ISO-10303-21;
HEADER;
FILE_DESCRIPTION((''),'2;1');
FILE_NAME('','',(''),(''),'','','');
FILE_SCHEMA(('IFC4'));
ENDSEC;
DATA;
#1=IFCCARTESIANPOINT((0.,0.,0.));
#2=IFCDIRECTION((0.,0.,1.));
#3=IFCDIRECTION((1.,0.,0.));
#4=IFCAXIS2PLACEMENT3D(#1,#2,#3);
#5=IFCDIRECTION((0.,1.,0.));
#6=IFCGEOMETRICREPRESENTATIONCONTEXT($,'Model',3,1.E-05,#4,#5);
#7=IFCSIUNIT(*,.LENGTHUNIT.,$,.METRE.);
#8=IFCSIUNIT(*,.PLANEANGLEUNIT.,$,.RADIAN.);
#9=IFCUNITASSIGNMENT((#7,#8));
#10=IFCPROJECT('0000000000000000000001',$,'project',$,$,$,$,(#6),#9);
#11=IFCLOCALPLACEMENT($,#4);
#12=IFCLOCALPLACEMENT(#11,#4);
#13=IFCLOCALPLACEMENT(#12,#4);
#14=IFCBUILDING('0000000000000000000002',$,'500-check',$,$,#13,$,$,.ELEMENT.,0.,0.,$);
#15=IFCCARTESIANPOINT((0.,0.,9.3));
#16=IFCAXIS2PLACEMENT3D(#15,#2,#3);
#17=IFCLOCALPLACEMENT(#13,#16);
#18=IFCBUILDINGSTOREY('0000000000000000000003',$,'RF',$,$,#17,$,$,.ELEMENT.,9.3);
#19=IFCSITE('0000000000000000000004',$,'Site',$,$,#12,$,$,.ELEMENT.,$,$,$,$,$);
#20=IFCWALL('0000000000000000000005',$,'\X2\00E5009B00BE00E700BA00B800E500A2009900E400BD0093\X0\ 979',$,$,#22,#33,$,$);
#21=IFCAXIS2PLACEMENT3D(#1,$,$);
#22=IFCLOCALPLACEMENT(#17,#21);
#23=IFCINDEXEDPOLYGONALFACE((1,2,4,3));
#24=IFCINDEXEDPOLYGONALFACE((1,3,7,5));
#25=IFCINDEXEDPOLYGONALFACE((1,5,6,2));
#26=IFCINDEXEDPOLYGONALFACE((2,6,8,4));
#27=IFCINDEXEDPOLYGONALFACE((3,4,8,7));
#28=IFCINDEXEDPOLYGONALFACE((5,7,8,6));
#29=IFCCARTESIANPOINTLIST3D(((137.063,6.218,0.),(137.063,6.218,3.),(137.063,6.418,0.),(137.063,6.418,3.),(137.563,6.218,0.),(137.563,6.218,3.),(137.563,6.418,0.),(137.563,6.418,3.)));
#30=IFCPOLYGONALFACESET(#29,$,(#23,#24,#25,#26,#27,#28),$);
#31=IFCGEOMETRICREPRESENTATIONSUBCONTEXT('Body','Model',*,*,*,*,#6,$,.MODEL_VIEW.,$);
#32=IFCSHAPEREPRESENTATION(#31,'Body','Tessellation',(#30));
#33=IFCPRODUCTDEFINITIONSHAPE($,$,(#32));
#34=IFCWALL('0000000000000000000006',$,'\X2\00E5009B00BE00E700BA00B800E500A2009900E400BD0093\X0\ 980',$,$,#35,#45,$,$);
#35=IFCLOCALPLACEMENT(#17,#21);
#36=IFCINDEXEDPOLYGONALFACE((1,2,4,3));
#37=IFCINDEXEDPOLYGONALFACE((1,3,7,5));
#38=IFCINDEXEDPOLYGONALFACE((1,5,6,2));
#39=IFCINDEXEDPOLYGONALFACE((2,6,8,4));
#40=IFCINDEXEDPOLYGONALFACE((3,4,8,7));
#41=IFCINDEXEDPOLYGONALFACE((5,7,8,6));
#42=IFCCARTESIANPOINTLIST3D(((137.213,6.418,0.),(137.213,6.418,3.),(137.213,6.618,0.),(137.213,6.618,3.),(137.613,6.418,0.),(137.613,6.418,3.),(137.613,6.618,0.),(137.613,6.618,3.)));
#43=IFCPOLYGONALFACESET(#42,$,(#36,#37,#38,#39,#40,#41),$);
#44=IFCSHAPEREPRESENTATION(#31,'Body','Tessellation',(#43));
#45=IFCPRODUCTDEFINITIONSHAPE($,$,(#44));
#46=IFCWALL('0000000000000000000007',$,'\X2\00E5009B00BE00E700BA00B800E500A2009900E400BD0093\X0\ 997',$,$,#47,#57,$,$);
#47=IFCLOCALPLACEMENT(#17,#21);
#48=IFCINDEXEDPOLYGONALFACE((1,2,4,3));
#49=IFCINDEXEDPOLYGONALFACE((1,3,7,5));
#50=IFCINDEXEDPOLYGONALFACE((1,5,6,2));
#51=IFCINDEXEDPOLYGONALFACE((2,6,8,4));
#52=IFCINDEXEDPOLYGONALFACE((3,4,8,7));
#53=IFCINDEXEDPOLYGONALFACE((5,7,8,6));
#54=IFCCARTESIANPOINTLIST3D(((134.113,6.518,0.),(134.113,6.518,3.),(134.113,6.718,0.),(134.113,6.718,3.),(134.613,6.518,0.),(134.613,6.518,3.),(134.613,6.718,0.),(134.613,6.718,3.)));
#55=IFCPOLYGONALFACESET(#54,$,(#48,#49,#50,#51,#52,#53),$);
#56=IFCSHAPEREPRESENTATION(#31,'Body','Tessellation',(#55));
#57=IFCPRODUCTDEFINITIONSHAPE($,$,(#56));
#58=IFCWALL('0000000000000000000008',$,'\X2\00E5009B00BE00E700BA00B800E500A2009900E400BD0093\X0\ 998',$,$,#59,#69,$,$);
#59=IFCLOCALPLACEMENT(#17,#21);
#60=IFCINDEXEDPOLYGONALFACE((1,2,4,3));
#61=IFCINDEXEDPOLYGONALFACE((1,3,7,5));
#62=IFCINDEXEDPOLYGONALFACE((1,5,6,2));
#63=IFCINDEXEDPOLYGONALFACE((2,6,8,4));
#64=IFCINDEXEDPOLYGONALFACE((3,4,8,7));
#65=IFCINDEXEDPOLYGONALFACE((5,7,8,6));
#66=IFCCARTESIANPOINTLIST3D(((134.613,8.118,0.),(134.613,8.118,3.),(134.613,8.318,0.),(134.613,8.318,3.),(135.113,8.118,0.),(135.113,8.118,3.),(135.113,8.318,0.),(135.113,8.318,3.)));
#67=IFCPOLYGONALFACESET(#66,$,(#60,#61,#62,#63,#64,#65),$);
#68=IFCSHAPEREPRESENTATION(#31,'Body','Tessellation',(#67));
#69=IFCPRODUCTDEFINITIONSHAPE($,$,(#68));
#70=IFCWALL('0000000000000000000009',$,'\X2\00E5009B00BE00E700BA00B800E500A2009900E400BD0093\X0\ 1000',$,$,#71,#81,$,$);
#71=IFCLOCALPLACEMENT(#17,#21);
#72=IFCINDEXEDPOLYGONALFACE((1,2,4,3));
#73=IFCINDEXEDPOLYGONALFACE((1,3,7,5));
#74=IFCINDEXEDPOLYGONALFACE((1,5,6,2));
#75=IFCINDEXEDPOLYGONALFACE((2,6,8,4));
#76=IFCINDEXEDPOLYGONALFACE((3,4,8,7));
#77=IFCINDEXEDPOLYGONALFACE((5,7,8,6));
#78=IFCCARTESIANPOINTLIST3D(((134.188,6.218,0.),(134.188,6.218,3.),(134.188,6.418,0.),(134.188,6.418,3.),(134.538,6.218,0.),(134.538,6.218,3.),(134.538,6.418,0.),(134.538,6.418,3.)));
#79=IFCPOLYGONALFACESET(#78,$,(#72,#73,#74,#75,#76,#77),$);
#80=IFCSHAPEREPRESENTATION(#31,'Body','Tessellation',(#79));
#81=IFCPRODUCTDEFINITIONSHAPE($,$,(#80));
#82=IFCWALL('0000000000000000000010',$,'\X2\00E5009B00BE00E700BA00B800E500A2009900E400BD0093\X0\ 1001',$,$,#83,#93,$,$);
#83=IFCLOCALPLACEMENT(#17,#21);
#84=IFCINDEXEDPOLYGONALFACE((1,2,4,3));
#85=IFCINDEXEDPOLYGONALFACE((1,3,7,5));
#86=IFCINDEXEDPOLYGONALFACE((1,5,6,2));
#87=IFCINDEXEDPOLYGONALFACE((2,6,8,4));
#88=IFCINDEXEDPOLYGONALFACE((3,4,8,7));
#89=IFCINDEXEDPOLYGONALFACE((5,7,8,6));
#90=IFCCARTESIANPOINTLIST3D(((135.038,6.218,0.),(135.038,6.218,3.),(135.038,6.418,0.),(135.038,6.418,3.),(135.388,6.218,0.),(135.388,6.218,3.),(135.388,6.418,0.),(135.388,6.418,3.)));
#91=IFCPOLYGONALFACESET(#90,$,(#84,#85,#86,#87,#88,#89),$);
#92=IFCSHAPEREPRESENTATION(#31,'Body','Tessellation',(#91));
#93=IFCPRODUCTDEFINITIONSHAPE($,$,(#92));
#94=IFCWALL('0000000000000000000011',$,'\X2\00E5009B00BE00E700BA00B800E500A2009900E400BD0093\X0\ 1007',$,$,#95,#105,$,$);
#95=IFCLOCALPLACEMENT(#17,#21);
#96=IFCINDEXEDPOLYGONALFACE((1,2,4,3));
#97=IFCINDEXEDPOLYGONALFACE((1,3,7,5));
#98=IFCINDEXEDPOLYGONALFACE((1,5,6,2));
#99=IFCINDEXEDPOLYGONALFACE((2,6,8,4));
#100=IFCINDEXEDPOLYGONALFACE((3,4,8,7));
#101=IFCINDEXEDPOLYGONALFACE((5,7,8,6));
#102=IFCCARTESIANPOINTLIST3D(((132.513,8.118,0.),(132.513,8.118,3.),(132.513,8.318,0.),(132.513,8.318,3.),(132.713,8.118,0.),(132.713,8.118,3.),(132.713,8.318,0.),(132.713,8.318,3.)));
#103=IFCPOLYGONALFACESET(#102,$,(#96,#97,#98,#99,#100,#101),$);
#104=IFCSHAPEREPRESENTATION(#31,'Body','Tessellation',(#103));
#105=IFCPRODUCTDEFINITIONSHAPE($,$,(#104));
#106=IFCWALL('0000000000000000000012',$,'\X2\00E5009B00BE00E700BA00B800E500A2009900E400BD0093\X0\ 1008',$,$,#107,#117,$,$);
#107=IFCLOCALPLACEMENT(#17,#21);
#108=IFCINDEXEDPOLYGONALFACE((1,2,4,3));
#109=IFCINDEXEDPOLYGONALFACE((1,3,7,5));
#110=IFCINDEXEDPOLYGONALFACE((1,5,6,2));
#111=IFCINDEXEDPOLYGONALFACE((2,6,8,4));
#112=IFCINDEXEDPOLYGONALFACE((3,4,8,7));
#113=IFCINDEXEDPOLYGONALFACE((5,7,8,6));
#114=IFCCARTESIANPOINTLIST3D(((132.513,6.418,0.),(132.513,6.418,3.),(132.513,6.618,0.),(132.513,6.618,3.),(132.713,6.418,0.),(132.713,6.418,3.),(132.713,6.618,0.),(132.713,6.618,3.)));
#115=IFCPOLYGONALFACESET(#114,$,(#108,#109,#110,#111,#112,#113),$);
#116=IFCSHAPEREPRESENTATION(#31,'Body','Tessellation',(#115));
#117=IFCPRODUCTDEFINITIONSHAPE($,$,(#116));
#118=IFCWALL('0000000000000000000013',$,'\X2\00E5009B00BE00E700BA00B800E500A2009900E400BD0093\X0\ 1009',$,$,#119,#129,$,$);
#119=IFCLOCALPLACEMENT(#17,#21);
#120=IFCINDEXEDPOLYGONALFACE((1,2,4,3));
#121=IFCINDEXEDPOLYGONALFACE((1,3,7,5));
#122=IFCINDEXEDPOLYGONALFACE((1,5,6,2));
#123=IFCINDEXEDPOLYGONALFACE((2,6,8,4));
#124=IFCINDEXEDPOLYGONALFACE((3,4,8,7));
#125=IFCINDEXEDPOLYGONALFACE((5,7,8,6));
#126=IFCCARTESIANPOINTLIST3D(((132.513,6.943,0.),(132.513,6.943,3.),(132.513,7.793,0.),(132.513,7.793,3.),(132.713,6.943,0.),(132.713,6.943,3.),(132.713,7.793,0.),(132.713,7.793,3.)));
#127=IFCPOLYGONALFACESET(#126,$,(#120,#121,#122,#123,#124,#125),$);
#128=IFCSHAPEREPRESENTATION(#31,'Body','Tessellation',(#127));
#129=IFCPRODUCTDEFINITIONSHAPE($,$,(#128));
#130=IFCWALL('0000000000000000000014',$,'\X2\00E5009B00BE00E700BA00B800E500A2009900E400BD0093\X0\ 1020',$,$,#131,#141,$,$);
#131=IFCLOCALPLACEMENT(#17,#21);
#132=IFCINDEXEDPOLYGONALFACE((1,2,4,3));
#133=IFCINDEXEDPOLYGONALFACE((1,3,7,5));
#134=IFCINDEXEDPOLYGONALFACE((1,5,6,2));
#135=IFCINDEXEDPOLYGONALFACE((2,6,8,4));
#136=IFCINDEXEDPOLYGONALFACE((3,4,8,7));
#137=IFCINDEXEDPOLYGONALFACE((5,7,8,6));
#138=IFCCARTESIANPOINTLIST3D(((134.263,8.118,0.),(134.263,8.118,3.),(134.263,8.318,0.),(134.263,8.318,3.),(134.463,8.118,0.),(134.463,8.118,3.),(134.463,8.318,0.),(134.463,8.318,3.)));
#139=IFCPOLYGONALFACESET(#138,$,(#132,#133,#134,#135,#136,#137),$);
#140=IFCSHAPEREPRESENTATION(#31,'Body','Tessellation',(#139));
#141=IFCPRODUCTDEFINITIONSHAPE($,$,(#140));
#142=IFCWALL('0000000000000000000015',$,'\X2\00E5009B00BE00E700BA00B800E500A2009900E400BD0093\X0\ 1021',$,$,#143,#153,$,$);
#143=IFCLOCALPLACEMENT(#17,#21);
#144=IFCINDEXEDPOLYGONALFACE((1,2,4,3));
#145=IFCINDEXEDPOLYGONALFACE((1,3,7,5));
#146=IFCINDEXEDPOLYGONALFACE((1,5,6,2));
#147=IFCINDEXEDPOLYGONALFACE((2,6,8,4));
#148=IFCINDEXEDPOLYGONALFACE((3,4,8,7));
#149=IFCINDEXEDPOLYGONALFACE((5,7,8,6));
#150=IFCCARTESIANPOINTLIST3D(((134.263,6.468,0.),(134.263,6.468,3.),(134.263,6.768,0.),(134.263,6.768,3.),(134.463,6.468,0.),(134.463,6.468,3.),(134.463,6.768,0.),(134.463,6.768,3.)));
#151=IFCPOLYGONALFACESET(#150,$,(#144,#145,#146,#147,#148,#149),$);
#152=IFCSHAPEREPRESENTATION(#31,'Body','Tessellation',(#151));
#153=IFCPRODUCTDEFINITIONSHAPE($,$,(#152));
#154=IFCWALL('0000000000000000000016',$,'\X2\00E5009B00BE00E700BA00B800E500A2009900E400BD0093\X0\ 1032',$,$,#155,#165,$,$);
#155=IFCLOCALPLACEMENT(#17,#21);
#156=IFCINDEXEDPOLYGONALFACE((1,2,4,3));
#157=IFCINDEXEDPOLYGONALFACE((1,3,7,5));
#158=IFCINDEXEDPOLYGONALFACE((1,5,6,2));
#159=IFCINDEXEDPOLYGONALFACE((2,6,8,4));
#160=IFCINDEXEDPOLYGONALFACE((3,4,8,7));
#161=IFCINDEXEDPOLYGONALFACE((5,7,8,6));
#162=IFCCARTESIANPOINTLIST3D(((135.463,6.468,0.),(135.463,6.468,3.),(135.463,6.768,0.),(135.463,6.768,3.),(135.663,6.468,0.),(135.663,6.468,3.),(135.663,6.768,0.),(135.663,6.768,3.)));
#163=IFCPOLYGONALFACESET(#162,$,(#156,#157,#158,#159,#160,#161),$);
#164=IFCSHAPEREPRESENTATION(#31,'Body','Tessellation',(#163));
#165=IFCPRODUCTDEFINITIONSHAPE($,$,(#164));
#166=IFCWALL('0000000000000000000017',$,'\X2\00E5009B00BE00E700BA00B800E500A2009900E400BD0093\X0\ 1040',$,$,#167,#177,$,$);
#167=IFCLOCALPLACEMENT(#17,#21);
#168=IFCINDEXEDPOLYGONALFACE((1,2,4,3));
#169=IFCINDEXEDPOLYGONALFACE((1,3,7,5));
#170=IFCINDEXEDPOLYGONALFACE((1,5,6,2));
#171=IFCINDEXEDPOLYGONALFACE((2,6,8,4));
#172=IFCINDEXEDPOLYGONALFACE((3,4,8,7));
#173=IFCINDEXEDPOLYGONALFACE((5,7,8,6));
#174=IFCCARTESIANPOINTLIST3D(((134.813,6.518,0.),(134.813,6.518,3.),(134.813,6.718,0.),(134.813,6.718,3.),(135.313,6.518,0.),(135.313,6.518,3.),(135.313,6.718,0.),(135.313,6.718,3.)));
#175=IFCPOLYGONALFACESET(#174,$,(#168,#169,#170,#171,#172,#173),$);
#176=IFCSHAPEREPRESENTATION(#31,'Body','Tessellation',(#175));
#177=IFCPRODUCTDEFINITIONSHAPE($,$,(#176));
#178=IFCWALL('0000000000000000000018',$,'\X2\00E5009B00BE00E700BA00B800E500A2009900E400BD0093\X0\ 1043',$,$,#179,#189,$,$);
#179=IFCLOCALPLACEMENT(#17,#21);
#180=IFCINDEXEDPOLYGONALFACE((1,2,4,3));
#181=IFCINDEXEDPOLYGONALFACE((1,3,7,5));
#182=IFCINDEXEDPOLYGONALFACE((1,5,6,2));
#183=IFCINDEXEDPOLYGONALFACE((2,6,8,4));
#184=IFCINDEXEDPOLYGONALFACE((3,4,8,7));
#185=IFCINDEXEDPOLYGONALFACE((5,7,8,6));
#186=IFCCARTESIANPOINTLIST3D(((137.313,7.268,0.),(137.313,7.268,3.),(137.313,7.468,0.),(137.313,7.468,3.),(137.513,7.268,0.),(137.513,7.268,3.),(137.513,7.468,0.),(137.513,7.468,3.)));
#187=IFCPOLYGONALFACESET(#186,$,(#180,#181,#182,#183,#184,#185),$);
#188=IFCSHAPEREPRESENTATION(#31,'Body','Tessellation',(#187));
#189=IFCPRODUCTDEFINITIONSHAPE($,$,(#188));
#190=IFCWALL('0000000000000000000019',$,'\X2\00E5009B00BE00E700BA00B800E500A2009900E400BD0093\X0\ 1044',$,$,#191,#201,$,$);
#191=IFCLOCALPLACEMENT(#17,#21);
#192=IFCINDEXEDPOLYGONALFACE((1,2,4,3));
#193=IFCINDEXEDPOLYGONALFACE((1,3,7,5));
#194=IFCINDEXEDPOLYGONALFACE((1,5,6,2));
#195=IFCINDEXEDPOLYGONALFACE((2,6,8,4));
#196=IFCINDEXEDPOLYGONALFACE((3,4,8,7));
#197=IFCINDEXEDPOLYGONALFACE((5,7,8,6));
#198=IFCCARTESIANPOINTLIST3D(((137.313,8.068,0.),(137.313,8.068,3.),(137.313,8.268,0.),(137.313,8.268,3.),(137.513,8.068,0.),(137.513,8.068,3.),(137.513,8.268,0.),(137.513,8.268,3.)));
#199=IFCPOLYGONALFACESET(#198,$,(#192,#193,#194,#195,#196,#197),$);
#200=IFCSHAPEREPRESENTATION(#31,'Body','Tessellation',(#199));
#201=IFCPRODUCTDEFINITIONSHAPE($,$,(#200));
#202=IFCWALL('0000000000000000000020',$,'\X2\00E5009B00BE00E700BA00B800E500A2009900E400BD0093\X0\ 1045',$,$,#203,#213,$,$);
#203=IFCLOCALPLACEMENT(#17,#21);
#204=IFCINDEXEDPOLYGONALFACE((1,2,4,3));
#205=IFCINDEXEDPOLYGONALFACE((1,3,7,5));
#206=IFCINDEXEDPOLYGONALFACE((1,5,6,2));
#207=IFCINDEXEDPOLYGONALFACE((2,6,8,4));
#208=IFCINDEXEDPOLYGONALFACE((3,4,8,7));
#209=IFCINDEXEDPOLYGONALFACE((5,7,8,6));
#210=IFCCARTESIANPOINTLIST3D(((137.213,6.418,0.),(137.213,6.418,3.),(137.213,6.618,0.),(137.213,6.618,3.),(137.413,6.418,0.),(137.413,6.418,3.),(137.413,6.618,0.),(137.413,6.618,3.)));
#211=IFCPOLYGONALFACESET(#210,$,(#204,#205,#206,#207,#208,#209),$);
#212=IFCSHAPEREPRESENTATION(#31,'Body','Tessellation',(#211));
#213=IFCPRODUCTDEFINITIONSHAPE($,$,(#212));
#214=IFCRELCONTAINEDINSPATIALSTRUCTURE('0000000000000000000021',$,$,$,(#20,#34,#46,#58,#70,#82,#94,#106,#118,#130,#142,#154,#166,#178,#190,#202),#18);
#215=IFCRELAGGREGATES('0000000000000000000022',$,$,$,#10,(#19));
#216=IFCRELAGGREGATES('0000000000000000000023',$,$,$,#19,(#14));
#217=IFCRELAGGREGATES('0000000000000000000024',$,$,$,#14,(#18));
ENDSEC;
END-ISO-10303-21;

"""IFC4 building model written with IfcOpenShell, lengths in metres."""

from ifc_helpers import new_model, si_unit, direction, frame, frame_2d, origin_with_axes, place, context, subcontext, project, spatial, rectangle, extrude, element, save


model = new_model("IFC4")

# Units and contexts
model_context = context("Model", 3, precision=1e-05, world=origin_with_axes(), true_north=direction((0.0, 1.0, 0.0)))
body_context = subcontext(model_context, "Body", "Model", "MODEL_VIEW")
ifc_project = project(units=[si_unit("LENGTHUNIT", "METRE"), si_unit("PLANEANGLEUNIT", "RADIAN")], contexts=[model_context])

# Site, building, storey
placement = place(None, origin_with_axes())
site_placement = place(placement, origin_with_axes())
site = spatial("IfcSite", under=ifc_project, at=site_placement, Name="Site", CompositionType="ELEMENT")
building_placement = place(site_placement, origin_with_axes())
building = spatial("IfcBuilding", under=site, at=building_placement, Name="500-check", CompositionType="ELEMENT", ElevationOfRefHeight=0.0, ElevationOfTerrain=0.0)
storey_placement = place(building_placement, frame((0.0, 0.0, 9.3), z_axis=(0.0, 0.0, 1.0), x_axis=(1.0, 0.0, 0.0)))
storey = spatial("IfcBuildingStorey", under=building, at=storey_placement, Name="RF", CompositionType="ELEMENT", Elevation=9.3)

# Walls
wall_1_placement = place(storey_placement, frame((137.313, 6.318, 0.0), z_axis=(0.0, 0.0, 1.0), x_axis=(1.0, 0.0, 0.0)))
element("IfcWall", 1, at=wall_1_placement, inside=storey, Name="å\u009b¾çº¸å¢\u0099ä½\u0093 979", context=body_context, shape_type="SweptSolid", body=[
    extrude(rectangle(XDim=0.5, YDim=0.2, at=frame_2d((0.0, 0.0), x_axis=(1.0, 0.0, 0.0))), frame((0.0, 0.0, 0.0), z_axis=(0.0, 0.0, 1.0)), (0.0, 0.0, 1.0), 3.0),
])
wall_2_placement = place(storey_placement, frame((137.413, 6.518, 0.0), z_axis=(0.0, 0.0, 1.0), x_axis=(1.0, 0.0, 0.0)))
element("IfcWall", 2, at=wall_2_placement, inside=storey, Name="å\u009b¾çº¸å¢\u0099ä½\u0093 980", context=body_context, shape_type="SweptSolid", body=[
    extrude(rectangle(XDim=0.4, YDim=0.2, at=frame_2d((0.0, 0.0), x_axis=(1.0, 0.0, 0.0))), frame((0.0, 0.0, 0.0), z_axis=(0.0, 0.0, 1.0)), (0.0, 0.0, 1.0), 3.0),
])
for number, where, z_axis, x_axis, name in (
    (3, (134.363, 6.618, 0.0), (0.0, 0.0, 1.0), (1.0, 0.0, 0.0), "å\u009b¾çº¸å¢\u0099ä½\u0093 997"),
    (4, (134.863, 8.218, 0.0), (0.0, 0.0, 1.0), (-1.0, 0.0, 0.0), "å\u009b¾çº¸å¢\u0099ä½\u0093 998"),
):
    element("IfcWall", number, at=place(storey_placement, frame(where, z_axis=z_axis, x_axis=x_axis)), inside=storey, Name=name, context=body_context, shape_type="SweptSolid", body=[
        extrude(rectangle(XDim=0.5, YDim=0.2, at=frame_2d((0.0, 0.0), x_axis=(1.0, 0.0, 0.0))), frame((0.0, 0.0, 0.0), z_axis=(0.0, 0.0, 1.0)), (0.0, 0.0, 1.0), 3.0),
    ])
for number, where, z_axis, x_axis, name in (
    (5, (134.363, 6.318, 0.0), (0.0, 0.0, 1.0), (1.0, 0.0, 0.0), "å\u009b¾çº¸å¢\u0099ä½\u0093 1000"),
    (6, (135.213, 6.318, 0.0), (0.0, 0.0, 1.0), (1.0, 0.0, 0.0), "å\u009b¾çº¸å¢\u0099ä½\u0093 1001"),
):
    element("IfcWall", number, at=place(storey_placement, frame(where, z_axis=z_axis, x_axis=x_axis)), inside=storey, Name=name, context=body_context, shape_type="SweptSolid", body=[
        extrude(rectangle(XDim=0.35, YDim=0.2, at=frame_2d((0.0, 0.0), x_axis=(1.0, 0.0, 0.0))), frame((0.0, 0.0, 0.0), z_axis=(0.0, 0.0, 1.0)), (0.0, 0.0, 1.0), 3.0),
    ])
for number, where, z_axis, x_axis, name in (
    (7, (132.613, 8.218, 0.0), (0.0, 0.0, 1.0), (0.0, 1.0, 0.0), "å\u009b¾çº¸å¢\u0099ä½\u0093 1007"),
    (8, (132.613, 6.518, 0.0), (0.0, 0.0, 1.0), (0.0, -1.0, 0.0), "å\u009b¾çº¸å¢\u0099ä½\u0093 1008"),
):
    element("IfcWall", number, at=place(storey_placement, frame(where, z_axis=z_axis, x_axis=x_axis)), inside=storey, Name=name, context=body_context, shape_type="SweptSolid", body=[
        extrude(rectangle(XDim=0.2, YDim=0.2, at=frame_2d((0.0, 0.0), x_axis=(1.0, 0.0, 0.0))), frame((0.0, 0.0, 0.0), z_axis=(0.0, 0.0, 1.0)), (0.0, 0.0, 1.0), 3.0),
    ])
wall_3_placement = place(storey_placement, frame((132.613, 7.368, 0.0), z_axis=(0.0, 0.0, 1.0), x_axis=(0.0, -1.0, 0.0)))
element("IfcWall", 9, at=wall_3_placement, inside=storey, Name="å\u009b¾çº¸å¢\u0099ä½\u0093 1009", context=body_context, shape_type="SweptSolid", body=[
    extrude(rectangle(XDim=0.85, YDim=0.2, at=frame_2d((0.0, 0.0), x_axis=(1.0, 0.0, 0.0))), frame((0.0, 0.0, 0.0), z_axis=(0.0, 0.0, 1.0)), (0.0, 0.0, 1.0), 3.0),
])
for number, where, z_axis, x_axis, name in (
    (10, (134.363, 8.218, 0.0), (0.0, 0.0, 1.0), (0.0, 1.0, 0.0), "å\u009b¾çº¸å¢\u0099ä½\u0093 1020"),
):
    element("IfcWall", number, at=place(storey_placement, frame(where, z_axis=z_axis, x_axis=x_axis)), inside=storey, Name=name, context=body_context, shape_type="SweptSolid", body=[
        extrude(rectangle(XDim=0.2, YDim=0.2, at=frame_2d((0.0, 0.0), x_axis=(1.0, 0.0, 0.0))), frame((0.0, 0.0, 0.0), z_axis=(0.0, 0.0, 1.0)), (0.0, 0.0, 1.0), 3.0),
    ])
for number, where, z_axis, x_axis, name in (
    (11, (134.363, 6.618, 0.0), (0.0, 0.0, 1.0), (0.0, -1.0, 0.0), "å\u009b¾çº¸å¢\u0099ä½\u0093 1021"),
    (12, (135.563, 6.618, 0.0), (0.0, 0.0, 1.0), (0.0, -1.0, 0.0), "å\u009b¾çº¸å¢\u0099ä½\u0093 1032"),
):
    element("IfcWall", number, at=place(storey_placement, frame(where, z_axis=z_axis, x_axis=x_axis)), inside=storey, Name=name, context=body_context, shape_type="SweptSolid", body=[
        extrude(rectangle(XDim=0.3, YDim=0.2, at=frame_2d((0.0, 0.0), x_axis=(1.0, 0.0, 0.0))), frame((0.0, 0.0, 0.0), z_axis=(0.0, 0.0, 1.0)), (0.0, 0.0, 1.0), 3.0),
    ])
wall_4_placement = place(storey_placement, frame((135.063, 6.618, 0.0), z_axis=(0.0, 0.0, 1.0), x_axis=(1.0, 0.0, 0.0)))
element("IfcWall", 13, at=wall_4_placement, inside=storey, Name="å\u009b¾çº¸å¢\u0099ä½\u0093 1040", context=body_context, shape_type="SweptSolid", body=[
    extrude(rectangle(XDim=0.5, YDim=0.2, at=frame_2d((0.0, 0.0), x_axis=(1.0, 0.0, 0.0))), frame((0.0, 0.0, 0.0), z_axis=(0.0, 0.0, 1.0)), (0.0, 0.0, 1.0), 3.0),
])
for number, where, z_axis, x_axis, name in (
    (14, (137.413, 7.368, 0.0), (0.0, 0.0, 1.0), (-1.0, 0.0, 0.0), "å\u009b¾çº¸å¢\u0099ä½\u0093 1043"),
    (15, (137.413, 8.168, 0.0), (0.0, 0.0, 1.0), (-1.0, 0.0, 0.0), "å\u009b¾çº¸å¢\u0099ä½\u0093 1044"),
    (16, (137.313, 6.518, 0.0), (0.0, 0.0, 1.0), (0.0, -1.0, 0.0), "å\u009b¾çº¸å¢\u0099ä½\u0093 1045"),
):
    element("IfcWall", number, at=place(storey_placement, frame(where, z_axis=z_axis, x_axis=x_axis)), inside=storey, Name=name, context=body_context, shape_type="SweptSolid", body=[
        extrude(rectangle(XDim=0.2, YDim=0.2, at=frame_2d((0.0, 0.0), x_axis=(1.0, 0.0, 0.0))), frame((0.0, 0.0, 0.0), z_axis=(0.0, 0.0, 1.0)), (0.0, 0.0, 1.0), 3.0),
    ])

save(model, "model.ifc")
